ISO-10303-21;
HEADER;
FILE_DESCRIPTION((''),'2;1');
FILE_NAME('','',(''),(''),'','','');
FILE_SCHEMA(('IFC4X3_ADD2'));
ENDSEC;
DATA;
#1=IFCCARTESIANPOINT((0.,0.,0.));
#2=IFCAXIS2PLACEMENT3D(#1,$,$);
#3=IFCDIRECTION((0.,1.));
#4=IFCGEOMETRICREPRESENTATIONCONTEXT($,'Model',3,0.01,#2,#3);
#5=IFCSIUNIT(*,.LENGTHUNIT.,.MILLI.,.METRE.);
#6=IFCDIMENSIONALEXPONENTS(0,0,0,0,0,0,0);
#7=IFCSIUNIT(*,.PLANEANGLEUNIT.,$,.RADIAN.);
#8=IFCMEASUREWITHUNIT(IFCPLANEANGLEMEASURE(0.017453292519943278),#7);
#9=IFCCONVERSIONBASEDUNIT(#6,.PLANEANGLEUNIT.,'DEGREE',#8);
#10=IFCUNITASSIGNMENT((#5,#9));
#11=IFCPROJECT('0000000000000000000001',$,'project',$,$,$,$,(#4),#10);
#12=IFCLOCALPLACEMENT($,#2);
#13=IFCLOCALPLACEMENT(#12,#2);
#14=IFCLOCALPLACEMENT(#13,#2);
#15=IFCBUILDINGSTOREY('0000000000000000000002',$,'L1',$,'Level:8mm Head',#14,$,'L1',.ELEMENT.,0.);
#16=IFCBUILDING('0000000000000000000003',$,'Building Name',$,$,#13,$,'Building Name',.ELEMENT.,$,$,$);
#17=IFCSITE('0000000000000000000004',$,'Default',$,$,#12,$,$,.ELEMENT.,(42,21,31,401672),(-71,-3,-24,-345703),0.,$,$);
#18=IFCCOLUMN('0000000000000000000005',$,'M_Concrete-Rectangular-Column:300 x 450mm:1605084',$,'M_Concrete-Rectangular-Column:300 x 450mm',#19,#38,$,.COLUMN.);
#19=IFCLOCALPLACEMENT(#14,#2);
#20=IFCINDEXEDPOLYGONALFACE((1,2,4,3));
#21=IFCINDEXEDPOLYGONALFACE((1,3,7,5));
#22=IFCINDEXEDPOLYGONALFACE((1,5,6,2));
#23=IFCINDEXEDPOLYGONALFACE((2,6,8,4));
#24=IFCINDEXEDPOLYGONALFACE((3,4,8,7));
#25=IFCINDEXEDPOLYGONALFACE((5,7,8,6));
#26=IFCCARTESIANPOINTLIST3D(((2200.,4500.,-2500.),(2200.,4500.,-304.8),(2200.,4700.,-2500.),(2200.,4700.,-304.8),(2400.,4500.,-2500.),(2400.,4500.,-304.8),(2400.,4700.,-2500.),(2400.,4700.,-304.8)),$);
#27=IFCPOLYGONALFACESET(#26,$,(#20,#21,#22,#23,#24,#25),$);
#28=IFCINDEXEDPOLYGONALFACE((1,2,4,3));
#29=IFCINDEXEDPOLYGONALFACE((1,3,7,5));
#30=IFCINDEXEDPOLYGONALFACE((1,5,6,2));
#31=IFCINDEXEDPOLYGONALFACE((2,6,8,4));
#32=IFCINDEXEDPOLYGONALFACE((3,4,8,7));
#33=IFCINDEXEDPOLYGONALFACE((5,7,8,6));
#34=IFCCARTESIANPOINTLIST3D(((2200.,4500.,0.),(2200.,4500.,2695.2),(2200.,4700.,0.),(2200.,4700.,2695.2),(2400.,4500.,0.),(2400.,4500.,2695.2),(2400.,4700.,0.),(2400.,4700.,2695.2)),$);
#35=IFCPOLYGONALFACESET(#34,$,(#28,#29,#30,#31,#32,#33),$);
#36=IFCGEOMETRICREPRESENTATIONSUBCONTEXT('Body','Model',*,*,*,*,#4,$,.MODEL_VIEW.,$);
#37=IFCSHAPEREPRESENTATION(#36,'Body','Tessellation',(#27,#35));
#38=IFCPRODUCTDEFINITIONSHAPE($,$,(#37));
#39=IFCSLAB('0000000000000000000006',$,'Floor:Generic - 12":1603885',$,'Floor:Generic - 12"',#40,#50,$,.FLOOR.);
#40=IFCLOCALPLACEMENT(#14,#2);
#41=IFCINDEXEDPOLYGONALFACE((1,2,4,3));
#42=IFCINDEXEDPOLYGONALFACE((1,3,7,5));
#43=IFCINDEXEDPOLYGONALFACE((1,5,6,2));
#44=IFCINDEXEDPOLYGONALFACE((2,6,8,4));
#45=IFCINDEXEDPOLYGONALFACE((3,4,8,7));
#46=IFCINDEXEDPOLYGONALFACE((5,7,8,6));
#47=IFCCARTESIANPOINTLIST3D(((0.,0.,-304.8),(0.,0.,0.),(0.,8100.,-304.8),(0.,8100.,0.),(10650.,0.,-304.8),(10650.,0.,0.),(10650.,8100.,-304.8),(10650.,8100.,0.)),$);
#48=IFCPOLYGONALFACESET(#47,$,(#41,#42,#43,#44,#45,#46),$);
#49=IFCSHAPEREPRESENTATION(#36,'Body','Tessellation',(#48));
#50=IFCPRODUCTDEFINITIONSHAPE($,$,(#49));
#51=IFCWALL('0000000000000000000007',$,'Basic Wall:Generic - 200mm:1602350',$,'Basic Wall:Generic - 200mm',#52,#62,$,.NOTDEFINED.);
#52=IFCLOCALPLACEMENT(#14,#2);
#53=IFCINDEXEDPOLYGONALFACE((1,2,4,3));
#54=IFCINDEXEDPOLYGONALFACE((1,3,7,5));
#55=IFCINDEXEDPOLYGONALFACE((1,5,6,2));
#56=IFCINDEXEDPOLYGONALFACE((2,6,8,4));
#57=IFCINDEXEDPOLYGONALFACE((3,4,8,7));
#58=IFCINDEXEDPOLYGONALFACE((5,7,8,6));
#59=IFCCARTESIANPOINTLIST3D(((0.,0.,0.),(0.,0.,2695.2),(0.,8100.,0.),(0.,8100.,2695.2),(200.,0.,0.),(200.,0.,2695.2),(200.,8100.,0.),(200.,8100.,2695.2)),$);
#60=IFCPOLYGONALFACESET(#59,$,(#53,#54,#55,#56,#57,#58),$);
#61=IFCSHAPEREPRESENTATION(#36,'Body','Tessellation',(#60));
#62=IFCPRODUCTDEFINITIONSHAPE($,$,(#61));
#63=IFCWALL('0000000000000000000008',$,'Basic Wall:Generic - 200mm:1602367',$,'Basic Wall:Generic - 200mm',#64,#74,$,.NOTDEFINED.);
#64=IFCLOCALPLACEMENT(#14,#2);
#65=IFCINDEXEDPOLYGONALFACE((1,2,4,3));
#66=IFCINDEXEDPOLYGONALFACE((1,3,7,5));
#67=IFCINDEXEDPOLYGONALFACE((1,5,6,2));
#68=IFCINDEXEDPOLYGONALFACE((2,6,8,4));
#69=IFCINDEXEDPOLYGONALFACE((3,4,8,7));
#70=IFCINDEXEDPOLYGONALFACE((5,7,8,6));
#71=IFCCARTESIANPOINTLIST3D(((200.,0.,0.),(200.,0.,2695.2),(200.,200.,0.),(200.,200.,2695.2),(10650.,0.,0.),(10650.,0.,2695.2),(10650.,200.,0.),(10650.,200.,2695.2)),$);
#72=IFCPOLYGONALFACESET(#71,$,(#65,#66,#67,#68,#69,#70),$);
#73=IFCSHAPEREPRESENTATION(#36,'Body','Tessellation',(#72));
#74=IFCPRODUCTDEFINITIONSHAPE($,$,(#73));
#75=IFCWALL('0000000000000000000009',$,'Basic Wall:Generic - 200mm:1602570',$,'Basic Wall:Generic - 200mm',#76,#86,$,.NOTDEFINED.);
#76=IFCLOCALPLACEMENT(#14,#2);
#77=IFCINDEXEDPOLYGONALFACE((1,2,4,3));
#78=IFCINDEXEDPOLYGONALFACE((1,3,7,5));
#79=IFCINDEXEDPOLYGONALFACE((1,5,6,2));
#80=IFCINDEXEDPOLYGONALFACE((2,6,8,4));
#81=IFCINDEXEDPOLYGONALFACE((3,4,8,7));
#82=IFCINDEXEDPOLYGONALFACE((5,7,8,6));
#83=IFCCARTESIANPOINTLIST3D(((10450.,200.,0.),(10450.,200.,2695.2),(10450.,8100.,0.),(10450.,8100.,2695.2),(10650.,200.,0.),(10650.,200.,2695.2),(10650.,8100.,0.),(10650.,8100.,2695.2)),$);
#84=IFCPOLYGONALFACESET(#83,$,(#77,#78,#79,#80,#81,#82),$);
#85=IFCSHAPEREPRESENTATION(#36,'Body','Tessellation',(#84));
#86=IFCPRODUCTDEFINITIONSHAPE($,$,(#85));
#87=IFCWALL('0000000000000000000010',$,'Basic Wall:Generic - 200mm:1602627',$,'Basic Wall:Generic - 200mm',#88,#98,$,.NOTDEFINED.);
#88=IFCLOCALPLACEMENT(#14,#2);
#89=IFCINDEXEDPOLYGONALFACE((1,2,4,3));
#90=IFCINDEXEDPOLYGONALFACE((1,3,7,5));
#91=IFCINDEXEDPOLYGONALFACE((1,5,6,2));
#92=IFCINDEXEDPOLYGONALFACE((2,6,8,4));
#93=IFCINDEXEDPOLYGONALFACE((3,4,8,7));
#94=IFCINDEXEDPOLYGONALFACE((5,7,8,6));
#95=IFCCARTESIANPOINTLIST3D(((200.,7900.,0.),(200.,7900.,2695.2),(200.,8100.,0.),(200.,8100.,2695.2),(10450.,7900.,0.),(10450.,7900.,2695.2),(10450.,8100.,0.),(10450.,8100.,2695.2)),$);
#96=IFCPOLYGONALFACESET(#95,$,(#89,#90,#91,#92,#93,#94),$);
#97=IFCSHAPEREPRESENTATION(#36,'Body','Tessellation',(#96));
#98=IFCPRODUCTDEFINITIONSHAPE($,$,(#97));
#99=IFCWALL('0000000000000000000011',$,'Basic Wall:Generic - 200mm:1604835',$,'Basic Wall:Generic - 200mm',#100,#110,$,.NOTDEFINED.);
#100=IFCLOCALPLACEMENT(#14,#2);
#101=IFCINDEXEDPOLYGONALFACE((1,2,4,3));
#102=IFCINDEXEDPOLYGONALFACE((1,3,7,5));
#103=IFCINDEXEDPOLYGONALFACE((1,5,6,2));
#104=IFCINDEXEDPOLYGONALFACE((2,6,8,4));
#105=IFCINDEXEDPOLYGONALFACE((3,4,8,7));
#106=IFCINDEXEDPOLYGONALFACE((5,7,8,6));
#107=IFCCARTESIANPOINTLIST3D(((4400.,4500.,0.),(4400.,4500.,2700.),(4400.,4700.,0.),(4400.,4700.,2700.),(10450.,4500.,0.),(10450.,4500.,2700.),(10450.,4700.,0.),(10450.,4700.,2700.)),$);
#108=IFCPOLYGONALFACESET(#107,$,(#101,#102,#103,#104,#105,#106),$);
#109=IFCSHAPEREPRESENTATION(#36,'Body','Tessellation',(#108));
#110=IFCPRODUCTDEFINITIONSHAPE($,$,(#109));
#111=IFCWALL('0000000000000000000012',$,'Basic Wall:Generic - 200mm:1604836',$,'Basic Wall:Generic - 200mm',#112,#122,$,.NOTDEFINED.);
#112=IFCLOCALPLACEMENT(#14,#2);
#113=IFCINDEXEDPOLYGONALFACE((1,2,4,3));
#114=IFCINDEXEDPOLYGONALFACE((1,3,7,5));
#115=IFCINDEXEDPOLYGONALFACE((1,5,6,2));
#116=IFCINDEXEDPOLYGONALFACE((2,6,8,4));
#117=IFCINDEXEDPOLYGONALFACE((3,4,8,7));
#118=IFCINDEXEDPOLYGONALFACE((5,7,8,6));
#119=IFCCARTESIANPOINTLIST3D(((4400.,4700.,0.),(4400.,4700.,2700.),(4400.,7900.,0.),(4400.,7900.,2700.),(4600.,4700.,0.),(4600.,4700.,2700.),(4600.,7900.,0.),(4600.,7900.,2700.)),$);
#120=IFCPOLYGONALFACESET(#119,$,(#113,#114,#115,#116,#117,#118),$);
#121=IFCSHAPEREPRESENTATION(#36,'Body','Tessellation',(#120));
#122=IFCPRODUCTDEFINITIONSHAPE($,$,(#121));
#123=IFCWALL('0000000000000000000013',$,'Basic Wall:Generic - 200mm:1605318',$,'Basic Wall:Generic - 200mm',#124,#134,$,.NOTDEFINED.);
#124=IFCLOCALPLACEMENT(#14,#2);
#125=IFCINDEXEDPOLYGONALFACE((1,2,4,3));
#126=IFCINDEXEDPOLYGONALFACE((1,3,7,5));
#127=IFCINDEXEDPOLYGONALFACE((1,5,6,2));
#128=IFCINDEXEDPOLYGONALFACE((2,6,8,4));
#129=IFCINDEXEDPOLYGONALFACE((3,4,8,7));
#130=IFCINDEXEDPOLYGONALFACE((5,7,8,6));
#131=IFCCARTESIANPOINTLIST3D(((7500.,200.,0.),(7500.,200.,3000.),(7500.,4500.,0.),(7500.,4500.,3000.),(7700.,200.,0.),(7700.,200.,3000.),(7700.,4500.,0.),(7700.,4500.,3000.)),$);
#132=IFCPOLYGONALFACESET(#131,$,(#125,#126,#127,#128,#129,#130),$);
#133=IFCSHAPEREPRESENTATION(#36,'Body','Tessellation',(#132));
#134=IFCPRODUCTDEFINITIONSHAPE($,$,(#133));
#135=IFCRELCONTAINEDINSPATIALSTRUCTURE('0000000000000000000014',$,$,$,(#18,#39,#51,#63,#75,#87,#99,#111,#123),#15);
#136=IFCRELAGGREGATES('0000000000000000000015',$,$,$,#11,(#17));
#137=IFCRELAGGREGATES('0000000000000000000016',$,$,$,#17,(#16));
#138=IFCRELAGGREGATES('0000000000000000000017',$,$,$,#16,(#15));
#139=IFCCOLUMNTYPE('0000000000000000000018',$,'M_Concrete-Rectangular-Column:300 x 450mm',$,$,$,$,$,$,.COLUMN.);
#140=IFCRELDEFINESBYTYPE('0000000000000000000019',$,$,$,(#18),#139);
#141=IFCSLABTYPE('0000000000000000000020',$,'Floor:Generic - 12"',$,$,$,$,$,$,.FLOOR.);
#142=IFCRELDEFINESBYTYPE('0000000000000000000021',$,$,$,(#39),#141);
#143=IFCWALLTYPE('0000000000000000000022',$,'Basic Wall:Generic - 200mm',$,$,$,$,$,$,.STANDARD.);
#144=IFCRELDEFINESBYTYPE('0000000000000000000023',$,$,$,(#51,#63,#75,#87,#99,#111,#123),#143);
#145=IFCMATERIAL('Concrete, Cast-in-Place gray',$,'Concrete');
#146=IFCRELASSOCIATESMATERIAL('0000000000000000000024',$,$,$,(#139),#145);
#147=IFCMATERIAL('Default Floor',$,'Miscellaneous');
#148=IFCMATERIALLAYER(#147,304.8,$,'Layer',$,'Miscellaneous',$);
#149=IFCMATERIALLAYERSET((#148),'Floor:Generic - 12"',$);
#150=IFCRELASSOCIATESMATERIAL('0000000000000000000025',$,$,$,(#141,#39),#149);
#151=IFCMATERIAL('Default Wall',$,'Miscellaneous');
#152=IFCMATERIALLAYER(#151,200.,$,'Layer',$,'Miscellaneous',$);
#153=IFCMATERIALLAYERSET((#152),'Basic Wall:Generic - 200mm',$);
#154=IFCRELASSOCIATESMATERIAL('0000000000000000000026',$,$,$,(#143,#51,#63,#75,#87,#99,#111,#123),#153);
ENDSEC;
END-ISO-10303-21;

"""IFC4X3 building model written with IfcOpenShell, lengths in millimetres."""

from ifc_helpers import new_model, entity, si_unit, converted_unit, direction, frame, frame_2d, origin, place, context, subcontext, project, spatial, polyline, rectangle, extrude, clip, bounded_halfspace, source, transform, mapped, material, layer, layer_set, layer_usage, material_profile, profile_set, type_object, type_shapes, element, save


model = new_model("IFC4X3")

# Units and contexts
model_context = context("Model", 3, precision=0.01, world=origin(), true_north=direction((0.0, 1.0)))
body_context = subcontext(model_context, "Body", "Model", "MODEL_VIEW")
ifc_project = project(units=[si_unit("LENGTHUNIT", "METRE", prefix="MILLI"), converted_unit("PLANEANGLEUNIT", "DEGREE", entity("IfcPlaneAngleMeasure", 0.017453292519943278), si_unit("PLANEANGLEUNIT", "RADIAN"), dimensions=[0, 0, 0, 0, 0, 0, 0])], contexts=[model_context])

# Site, building, storey
site_placement = place(None, origin())
site = spatial("IfcSite", under=ifc_project, at=site_placement, Name="Default", CompositionType="ELEMENT", RefLatitude=(42, 21, 31, 401672), RefLongitude=(-71, -3, -24, -345703), RefElevation=0.0)
building_placement = place(site_placement, origin())
building = spatial("IfcBuilding", under=site, at=building_placement, Name="Building Name", LongName="Building Name", CompositionType="ELEMENT")
storey_placement = place(building_placement, origin())
storey = spatial("IfcBuildingStorey", under=building, at=storey_placement, Name="L1", ObjectType="Level:8mm Head", LongName="L1", CompositionType="ELEMENT", Elevation=0.0)

# Column
ifc_material_1 = material(Name="Concrete, Cast-in-Place gray", Category="Concrete")
ifc_material_profile_1 = material_profile(ifc_material_1, rectangle(XDim=200.0, YDim=200.0, at=frame_2d((0.0, 0.0), x_axis=(1.0, 0.0))), Name="300 x 450mm")
ifc_material_profile_2 = material_profile(ifc_material_1, rectangle(XDim=200.0, YDim=200.0, at=frame_2d((0.0, 0.0), x_axis=(1.0, 0.0))), Name="300 x 450mm")
ifc_profile_set = profile_set([ifc_material_profile_1, ifc_material_profile_2], Name="300 x 450mm")
column_type = type_object("IfcColumnType", Name="M_Concrete-Rectangular-Column:300 x 450mm", PredefinedType="COLUMN", material=ifc_profile_set)
shared_shape = source(origin(), body_context, "Body", "SweptSolid", [
    extrude(rectangle(XDim=200.0, YDim=200.0, at=frame_2d((0.0, 0.0), x_axis=(1.0, 0.0))), frame((2300.0, 4600.0, -2500.0), z_axis=(0.0, 0.0, 1.0), x_axis=(-1.0, 0.0, 0.0)), (0.0, 0.0, 1.0), 2195.2),
    extrude(rectangle(XDim=200.0, YDim=200.0, at=frame_2d((0.0, 0.0), x_axis=(1.0, 0.0))), frame((2300.0, 4600.0, 0.0), z_axis=(0.0, 0.0, 1.0), x_axis=(-1.0, 0.0, 0.0)), (0.0, 0.0, 1.0), 2695.2),
])
type_shapes(column_type, [shared_shape])
column_placement = place(storey_placement, origin())
element("IfcColumn", 1, at=column_placement, inside=storey, type_object=column_type, Name="M_Concrete-Rectangular-Column:300 x 450mm:1605084", ObjectType="M_Concrete-Rectangular-Column:300 x 450mm", PredefinedType="COLUMN", context=body_context, shape_type="MappedRepresentation", body=[
    mapped(shared_shape, transform((0.0, 0.0, 0.0), scale=1.0)),
])

# Slab
ifc_material_2 = material(Name="Default Floor", Category="Miscellaneous")
ifc_layer_1 = layer(ifc_material_2, 304.8, Name="Layer", Category="Miscellaneous")
ifc_layer_set_1 = layer_set([ifc_layer_1], Name="Floor:Generic - 12\"")
ifc_layer_usage = layer_usage(ifc_layer_set_1, "AXIS3", "POSITIVE", 0.0)
slab_type = type_object("IfcSlabType", Name="Floor:Generic - 12\"", PredefinedType="FLOOR", material=ifc_layer_set_1)
slab_placement = place(storey_placement, origin())
element("IfcSlab", 2, at=slab_placement, inside=storey, type_object=slab_type, material=ifc_layer_usage, Name="Floor:Generic - 12\":1603885", ObjectType="Floor:Generic - 12\"", PredefinedType="FLOOR", context=body_context, shape_type="SweptSolid", body=[
    extrude(rectangle(XDim=8100.0, YDim=10650.0, at=frame_2d((0.0, 0.0), x_axis=(1.0, 0.0))), frame((5325.0, 4050.0, 0.0), z_axis=(0.0, 0.0, -1.0), x_axis=(0.0, 1.0, 0.0)), (0.0, 0.0, 1.0), 304.8),
])

# Walls
ifc_material_3 = material(Name="Default Wall", Category="Miscellaneous")
ifc_layer_2 = layer(ifc_material_3, 200.0, Name="Layer", Category="Miscellaneous")
ifc_layer_set_2 = layer_set([ifc_layer_2], Name="Basic Wall:Generic - 200mm")
wall_type = type_object("IfcWallType", Name="Basic Wall:Generic - 200mm", PredefinedType="STANDARD", material=ifc_layer_set_2)
wall_1_placement = place(storey_placement, frame((100.0, 8100.0, 0.0), z_axis=(0.0, 0.0, 1.0), x_axis=(0.0, -1.0, 0.0)))
element("IfcWall", 3, at=wall_1_placement, inside=storey, type_object=wall_type, material=ifc_layer_set_2, Name="Basic Wall:Generic - 200mm:1602350", ObjectType="Basic Wall:Generic - 200mm", PredefinedType="NOTDEFINED", context=body_context, shape_type="Clipping", body=[
    clip(extrude(rectangle(XDim=8100.0, YDim=200.0, at=frame_2d((4050.0, 0.0), x_axis=(-1.0, 0.0))), origin(), (0.0, 0.0, 1.0), 2695.2), bounded_halfspace(frame((0.0, -100.0, 2695.2), z_axis=(0.0, 0.0, -1.0), x_axis=(0.0, 1.0, 0.0)), True, frame((0.0, -100.0, 2695.2)), polyline([(0.0, 0.0), (8100.0, 0.0), (8100.0, 200.0), (7900.0, 200.0), (200.0, 200.0), (0.0, 200.0), (0.0, 0.0)]))),
])
wall_2_placement = place(storey_placement, frame((200.0, 100.0, 0.0)))
element("IfcWall", 4, at=wall_2_placement, inside=storey, type_object=wall_type, material=ifc_layer_set_2, Name="Basic Wall:Generic - 200mm:1602367", ObjectType="Basic Wall:Generic - 200mm", PredefinedType="NOTDEFINED", context=body_context, shape_type="Clipping", body=[
    clip(extrude(rectangle(XDim=10450.0, YDim=200.0, at=frame_2d((5225.0, 0.0), x_axis=(-1.0, 0.0))), origin(), (0.0, 0.0, 1.0), 2695.2), bounded_halfspace(frame((0.0, -100.0, 2695.2), z_axis=(0.0, 0.0, -1.0), x_axis=(1.0, 0.0, 0.0)), True, frame((0.0, -100.0, 2695.2)), polyline([(0.0, 0.0), (10450.0, 0.0), (10450.0, 200.0), (10250.0, 200.0), (0.0, 200.0), (0.0, 0.0)]))),
])
wall_3_placement = place(storey_placement, frame((10550.0, 200.0, 0.0), z_axis=(0.0, 0.0, 1.0), x_axis=(0.0, 1.0, 0.0)))
element("IfcWall", 5, at=wall_3_placement, inside=storey, type_object=wall_type, material=ifc_layer_set_2, Name="Basic Wall:Generic - 200mm:1602570", ObjectType="Basic Wall:Generic - 200mm", PredefinedType="NOTDEFINED", context=body_context, shape_type="Clipping", body=[
    clip(extrude(rectangle(XDim=7900.0, YDim=200.0, at=frame_2d((3950.0, 0.0), x_axis=(-1.0, 0.0))), origin(), (0.0, 0.0, 1.0), 2695.2), bounded_halfspace(frame((0.0, -100.0, 2695.2), z_axis=(0.0, 0.0, -1.0), x_axis=(0.0, -1.0, 0.0)), True, frame((0.0, -100.0, 2695.2)), polyline([(0.0, 0.0), (7900.0, 0.0), (7900.0, 200.0), (7700.0, 200.0), (0.0, 200.0), (0.0, 0.0)]))),
])
wall_4_placement = place(storey_placement, frame((10450.0, 8000.0, 0.0), z_axis=(0.0, 0.0, 1.0), x_axis=(-1.0, 0.0, 0.0)))
element("IfcWall", 6, at=wall_4_placement, inside=storey, type_object=wall_type, material=ifc_layer_set_2, Name="Basic Wall:Generic - 200mm:1602627", ObjectType="Basic Wall:Generic - 200mm", PredefinedType="NOTDEFINED", context=body_context, shape_type="Clipping", body=[
    clip(extrude(rectangle(XDim=10250.0, YDim=200.0, at=frame_2d((5125.0, 0.0), x_axis=(-1.0, 0.0))), origin(), (0.0, 0.0, 1.0), 2695.2), bounded_halfspace(frame((0.0, -100.0, 2695.2), z_axis=(0.0, 0.0, -1.0), x_axis=(-1.0, 0.0, 0.0)), True, frame((0.0, -100.0, 2695.2)), polyline([(0.0, 0.0), (10250.0, 0.0), (10250.0, 200.0), (0.0, 200.0), (0.0, 0.0)]))),
])
wall_5_placement = place(storey_placement, frame((10450.0, 4600.0, 0.0), z_axis=(0.0, 0.0, 1.0), x_axis=(-1.0, 0.0, 0.0)))
element("IfcWall", 7, at=wall_5_placement, inside=storey, type_object=wall_type, material=ifc_layer_set_2, Name="Basic Wall:Generic - 200mm:1604835", ObjectType="Basic Wall:Generic - 200mm", PredefinedType="NOTDEFINED", context=body_context, shape_type="SweptSolid", body=[
    extrude(rectangle(XDim=6050.0, YDim=200.0, at=frame_2d((3025.0, 0.0), x_axis=(-1.0, 0.0))), origin(), (0.0, 0.0, 1.0), 2700.0),
])
wall_6_placement = place(storey_placement, frame((4500.0, 4700.0, 0.0), z_axis=(0.0, 0.0, 1.0), x_axis=(0.0, 1.0, 0.0)))
element("IfcWall", 8, at=wall_6_placement, inside=storey, type_object=wall_type, material=ifc_layer_set_2, Name="Basic Wall:Generic - 200mm:1604836", ObjectType="Basic Wall:Generic - 200mm", PredefinedType="NOTDEFINED", context=body_context, shape_type="SweptSolid", body=[
    extrude(rectangle(XDim=3200.0, YDim=200.0, at=frame_2d((1600.0, 0.0), x_axis=(-1.0, 0.0))), origin(), (0.0, 0.0, 1.0), 2700.0),
])
wall_7_placement = place(storey_placement, frame((7600.0, 4500.0, 0.0), z_axis=(0.0, 0.0, 1.0), x_axis=(0.0, -1.0, 0.0)))
element("IfcWall", 9, at=wall_7_placement, inside=storey, type_object=wall_type, material=ifc_layer_set_2, Name="Basic Wall:Generic - 200mm:1605318", ObjectType="Basic Wall:Generic - 200mm", PredefinedType="NOTDEFINED", context=body_context, shape_type="SweptSolid", body=[
    extrude(rectangle(XDim=4300.0, YDim=200.0, at=frame_2d((2150.0, 0.0), x_axis=(-1.0, 0.0))), origin(), (0.0, 0.0, 1.0), 3000.0),
])

save(model, "model.ifc")
